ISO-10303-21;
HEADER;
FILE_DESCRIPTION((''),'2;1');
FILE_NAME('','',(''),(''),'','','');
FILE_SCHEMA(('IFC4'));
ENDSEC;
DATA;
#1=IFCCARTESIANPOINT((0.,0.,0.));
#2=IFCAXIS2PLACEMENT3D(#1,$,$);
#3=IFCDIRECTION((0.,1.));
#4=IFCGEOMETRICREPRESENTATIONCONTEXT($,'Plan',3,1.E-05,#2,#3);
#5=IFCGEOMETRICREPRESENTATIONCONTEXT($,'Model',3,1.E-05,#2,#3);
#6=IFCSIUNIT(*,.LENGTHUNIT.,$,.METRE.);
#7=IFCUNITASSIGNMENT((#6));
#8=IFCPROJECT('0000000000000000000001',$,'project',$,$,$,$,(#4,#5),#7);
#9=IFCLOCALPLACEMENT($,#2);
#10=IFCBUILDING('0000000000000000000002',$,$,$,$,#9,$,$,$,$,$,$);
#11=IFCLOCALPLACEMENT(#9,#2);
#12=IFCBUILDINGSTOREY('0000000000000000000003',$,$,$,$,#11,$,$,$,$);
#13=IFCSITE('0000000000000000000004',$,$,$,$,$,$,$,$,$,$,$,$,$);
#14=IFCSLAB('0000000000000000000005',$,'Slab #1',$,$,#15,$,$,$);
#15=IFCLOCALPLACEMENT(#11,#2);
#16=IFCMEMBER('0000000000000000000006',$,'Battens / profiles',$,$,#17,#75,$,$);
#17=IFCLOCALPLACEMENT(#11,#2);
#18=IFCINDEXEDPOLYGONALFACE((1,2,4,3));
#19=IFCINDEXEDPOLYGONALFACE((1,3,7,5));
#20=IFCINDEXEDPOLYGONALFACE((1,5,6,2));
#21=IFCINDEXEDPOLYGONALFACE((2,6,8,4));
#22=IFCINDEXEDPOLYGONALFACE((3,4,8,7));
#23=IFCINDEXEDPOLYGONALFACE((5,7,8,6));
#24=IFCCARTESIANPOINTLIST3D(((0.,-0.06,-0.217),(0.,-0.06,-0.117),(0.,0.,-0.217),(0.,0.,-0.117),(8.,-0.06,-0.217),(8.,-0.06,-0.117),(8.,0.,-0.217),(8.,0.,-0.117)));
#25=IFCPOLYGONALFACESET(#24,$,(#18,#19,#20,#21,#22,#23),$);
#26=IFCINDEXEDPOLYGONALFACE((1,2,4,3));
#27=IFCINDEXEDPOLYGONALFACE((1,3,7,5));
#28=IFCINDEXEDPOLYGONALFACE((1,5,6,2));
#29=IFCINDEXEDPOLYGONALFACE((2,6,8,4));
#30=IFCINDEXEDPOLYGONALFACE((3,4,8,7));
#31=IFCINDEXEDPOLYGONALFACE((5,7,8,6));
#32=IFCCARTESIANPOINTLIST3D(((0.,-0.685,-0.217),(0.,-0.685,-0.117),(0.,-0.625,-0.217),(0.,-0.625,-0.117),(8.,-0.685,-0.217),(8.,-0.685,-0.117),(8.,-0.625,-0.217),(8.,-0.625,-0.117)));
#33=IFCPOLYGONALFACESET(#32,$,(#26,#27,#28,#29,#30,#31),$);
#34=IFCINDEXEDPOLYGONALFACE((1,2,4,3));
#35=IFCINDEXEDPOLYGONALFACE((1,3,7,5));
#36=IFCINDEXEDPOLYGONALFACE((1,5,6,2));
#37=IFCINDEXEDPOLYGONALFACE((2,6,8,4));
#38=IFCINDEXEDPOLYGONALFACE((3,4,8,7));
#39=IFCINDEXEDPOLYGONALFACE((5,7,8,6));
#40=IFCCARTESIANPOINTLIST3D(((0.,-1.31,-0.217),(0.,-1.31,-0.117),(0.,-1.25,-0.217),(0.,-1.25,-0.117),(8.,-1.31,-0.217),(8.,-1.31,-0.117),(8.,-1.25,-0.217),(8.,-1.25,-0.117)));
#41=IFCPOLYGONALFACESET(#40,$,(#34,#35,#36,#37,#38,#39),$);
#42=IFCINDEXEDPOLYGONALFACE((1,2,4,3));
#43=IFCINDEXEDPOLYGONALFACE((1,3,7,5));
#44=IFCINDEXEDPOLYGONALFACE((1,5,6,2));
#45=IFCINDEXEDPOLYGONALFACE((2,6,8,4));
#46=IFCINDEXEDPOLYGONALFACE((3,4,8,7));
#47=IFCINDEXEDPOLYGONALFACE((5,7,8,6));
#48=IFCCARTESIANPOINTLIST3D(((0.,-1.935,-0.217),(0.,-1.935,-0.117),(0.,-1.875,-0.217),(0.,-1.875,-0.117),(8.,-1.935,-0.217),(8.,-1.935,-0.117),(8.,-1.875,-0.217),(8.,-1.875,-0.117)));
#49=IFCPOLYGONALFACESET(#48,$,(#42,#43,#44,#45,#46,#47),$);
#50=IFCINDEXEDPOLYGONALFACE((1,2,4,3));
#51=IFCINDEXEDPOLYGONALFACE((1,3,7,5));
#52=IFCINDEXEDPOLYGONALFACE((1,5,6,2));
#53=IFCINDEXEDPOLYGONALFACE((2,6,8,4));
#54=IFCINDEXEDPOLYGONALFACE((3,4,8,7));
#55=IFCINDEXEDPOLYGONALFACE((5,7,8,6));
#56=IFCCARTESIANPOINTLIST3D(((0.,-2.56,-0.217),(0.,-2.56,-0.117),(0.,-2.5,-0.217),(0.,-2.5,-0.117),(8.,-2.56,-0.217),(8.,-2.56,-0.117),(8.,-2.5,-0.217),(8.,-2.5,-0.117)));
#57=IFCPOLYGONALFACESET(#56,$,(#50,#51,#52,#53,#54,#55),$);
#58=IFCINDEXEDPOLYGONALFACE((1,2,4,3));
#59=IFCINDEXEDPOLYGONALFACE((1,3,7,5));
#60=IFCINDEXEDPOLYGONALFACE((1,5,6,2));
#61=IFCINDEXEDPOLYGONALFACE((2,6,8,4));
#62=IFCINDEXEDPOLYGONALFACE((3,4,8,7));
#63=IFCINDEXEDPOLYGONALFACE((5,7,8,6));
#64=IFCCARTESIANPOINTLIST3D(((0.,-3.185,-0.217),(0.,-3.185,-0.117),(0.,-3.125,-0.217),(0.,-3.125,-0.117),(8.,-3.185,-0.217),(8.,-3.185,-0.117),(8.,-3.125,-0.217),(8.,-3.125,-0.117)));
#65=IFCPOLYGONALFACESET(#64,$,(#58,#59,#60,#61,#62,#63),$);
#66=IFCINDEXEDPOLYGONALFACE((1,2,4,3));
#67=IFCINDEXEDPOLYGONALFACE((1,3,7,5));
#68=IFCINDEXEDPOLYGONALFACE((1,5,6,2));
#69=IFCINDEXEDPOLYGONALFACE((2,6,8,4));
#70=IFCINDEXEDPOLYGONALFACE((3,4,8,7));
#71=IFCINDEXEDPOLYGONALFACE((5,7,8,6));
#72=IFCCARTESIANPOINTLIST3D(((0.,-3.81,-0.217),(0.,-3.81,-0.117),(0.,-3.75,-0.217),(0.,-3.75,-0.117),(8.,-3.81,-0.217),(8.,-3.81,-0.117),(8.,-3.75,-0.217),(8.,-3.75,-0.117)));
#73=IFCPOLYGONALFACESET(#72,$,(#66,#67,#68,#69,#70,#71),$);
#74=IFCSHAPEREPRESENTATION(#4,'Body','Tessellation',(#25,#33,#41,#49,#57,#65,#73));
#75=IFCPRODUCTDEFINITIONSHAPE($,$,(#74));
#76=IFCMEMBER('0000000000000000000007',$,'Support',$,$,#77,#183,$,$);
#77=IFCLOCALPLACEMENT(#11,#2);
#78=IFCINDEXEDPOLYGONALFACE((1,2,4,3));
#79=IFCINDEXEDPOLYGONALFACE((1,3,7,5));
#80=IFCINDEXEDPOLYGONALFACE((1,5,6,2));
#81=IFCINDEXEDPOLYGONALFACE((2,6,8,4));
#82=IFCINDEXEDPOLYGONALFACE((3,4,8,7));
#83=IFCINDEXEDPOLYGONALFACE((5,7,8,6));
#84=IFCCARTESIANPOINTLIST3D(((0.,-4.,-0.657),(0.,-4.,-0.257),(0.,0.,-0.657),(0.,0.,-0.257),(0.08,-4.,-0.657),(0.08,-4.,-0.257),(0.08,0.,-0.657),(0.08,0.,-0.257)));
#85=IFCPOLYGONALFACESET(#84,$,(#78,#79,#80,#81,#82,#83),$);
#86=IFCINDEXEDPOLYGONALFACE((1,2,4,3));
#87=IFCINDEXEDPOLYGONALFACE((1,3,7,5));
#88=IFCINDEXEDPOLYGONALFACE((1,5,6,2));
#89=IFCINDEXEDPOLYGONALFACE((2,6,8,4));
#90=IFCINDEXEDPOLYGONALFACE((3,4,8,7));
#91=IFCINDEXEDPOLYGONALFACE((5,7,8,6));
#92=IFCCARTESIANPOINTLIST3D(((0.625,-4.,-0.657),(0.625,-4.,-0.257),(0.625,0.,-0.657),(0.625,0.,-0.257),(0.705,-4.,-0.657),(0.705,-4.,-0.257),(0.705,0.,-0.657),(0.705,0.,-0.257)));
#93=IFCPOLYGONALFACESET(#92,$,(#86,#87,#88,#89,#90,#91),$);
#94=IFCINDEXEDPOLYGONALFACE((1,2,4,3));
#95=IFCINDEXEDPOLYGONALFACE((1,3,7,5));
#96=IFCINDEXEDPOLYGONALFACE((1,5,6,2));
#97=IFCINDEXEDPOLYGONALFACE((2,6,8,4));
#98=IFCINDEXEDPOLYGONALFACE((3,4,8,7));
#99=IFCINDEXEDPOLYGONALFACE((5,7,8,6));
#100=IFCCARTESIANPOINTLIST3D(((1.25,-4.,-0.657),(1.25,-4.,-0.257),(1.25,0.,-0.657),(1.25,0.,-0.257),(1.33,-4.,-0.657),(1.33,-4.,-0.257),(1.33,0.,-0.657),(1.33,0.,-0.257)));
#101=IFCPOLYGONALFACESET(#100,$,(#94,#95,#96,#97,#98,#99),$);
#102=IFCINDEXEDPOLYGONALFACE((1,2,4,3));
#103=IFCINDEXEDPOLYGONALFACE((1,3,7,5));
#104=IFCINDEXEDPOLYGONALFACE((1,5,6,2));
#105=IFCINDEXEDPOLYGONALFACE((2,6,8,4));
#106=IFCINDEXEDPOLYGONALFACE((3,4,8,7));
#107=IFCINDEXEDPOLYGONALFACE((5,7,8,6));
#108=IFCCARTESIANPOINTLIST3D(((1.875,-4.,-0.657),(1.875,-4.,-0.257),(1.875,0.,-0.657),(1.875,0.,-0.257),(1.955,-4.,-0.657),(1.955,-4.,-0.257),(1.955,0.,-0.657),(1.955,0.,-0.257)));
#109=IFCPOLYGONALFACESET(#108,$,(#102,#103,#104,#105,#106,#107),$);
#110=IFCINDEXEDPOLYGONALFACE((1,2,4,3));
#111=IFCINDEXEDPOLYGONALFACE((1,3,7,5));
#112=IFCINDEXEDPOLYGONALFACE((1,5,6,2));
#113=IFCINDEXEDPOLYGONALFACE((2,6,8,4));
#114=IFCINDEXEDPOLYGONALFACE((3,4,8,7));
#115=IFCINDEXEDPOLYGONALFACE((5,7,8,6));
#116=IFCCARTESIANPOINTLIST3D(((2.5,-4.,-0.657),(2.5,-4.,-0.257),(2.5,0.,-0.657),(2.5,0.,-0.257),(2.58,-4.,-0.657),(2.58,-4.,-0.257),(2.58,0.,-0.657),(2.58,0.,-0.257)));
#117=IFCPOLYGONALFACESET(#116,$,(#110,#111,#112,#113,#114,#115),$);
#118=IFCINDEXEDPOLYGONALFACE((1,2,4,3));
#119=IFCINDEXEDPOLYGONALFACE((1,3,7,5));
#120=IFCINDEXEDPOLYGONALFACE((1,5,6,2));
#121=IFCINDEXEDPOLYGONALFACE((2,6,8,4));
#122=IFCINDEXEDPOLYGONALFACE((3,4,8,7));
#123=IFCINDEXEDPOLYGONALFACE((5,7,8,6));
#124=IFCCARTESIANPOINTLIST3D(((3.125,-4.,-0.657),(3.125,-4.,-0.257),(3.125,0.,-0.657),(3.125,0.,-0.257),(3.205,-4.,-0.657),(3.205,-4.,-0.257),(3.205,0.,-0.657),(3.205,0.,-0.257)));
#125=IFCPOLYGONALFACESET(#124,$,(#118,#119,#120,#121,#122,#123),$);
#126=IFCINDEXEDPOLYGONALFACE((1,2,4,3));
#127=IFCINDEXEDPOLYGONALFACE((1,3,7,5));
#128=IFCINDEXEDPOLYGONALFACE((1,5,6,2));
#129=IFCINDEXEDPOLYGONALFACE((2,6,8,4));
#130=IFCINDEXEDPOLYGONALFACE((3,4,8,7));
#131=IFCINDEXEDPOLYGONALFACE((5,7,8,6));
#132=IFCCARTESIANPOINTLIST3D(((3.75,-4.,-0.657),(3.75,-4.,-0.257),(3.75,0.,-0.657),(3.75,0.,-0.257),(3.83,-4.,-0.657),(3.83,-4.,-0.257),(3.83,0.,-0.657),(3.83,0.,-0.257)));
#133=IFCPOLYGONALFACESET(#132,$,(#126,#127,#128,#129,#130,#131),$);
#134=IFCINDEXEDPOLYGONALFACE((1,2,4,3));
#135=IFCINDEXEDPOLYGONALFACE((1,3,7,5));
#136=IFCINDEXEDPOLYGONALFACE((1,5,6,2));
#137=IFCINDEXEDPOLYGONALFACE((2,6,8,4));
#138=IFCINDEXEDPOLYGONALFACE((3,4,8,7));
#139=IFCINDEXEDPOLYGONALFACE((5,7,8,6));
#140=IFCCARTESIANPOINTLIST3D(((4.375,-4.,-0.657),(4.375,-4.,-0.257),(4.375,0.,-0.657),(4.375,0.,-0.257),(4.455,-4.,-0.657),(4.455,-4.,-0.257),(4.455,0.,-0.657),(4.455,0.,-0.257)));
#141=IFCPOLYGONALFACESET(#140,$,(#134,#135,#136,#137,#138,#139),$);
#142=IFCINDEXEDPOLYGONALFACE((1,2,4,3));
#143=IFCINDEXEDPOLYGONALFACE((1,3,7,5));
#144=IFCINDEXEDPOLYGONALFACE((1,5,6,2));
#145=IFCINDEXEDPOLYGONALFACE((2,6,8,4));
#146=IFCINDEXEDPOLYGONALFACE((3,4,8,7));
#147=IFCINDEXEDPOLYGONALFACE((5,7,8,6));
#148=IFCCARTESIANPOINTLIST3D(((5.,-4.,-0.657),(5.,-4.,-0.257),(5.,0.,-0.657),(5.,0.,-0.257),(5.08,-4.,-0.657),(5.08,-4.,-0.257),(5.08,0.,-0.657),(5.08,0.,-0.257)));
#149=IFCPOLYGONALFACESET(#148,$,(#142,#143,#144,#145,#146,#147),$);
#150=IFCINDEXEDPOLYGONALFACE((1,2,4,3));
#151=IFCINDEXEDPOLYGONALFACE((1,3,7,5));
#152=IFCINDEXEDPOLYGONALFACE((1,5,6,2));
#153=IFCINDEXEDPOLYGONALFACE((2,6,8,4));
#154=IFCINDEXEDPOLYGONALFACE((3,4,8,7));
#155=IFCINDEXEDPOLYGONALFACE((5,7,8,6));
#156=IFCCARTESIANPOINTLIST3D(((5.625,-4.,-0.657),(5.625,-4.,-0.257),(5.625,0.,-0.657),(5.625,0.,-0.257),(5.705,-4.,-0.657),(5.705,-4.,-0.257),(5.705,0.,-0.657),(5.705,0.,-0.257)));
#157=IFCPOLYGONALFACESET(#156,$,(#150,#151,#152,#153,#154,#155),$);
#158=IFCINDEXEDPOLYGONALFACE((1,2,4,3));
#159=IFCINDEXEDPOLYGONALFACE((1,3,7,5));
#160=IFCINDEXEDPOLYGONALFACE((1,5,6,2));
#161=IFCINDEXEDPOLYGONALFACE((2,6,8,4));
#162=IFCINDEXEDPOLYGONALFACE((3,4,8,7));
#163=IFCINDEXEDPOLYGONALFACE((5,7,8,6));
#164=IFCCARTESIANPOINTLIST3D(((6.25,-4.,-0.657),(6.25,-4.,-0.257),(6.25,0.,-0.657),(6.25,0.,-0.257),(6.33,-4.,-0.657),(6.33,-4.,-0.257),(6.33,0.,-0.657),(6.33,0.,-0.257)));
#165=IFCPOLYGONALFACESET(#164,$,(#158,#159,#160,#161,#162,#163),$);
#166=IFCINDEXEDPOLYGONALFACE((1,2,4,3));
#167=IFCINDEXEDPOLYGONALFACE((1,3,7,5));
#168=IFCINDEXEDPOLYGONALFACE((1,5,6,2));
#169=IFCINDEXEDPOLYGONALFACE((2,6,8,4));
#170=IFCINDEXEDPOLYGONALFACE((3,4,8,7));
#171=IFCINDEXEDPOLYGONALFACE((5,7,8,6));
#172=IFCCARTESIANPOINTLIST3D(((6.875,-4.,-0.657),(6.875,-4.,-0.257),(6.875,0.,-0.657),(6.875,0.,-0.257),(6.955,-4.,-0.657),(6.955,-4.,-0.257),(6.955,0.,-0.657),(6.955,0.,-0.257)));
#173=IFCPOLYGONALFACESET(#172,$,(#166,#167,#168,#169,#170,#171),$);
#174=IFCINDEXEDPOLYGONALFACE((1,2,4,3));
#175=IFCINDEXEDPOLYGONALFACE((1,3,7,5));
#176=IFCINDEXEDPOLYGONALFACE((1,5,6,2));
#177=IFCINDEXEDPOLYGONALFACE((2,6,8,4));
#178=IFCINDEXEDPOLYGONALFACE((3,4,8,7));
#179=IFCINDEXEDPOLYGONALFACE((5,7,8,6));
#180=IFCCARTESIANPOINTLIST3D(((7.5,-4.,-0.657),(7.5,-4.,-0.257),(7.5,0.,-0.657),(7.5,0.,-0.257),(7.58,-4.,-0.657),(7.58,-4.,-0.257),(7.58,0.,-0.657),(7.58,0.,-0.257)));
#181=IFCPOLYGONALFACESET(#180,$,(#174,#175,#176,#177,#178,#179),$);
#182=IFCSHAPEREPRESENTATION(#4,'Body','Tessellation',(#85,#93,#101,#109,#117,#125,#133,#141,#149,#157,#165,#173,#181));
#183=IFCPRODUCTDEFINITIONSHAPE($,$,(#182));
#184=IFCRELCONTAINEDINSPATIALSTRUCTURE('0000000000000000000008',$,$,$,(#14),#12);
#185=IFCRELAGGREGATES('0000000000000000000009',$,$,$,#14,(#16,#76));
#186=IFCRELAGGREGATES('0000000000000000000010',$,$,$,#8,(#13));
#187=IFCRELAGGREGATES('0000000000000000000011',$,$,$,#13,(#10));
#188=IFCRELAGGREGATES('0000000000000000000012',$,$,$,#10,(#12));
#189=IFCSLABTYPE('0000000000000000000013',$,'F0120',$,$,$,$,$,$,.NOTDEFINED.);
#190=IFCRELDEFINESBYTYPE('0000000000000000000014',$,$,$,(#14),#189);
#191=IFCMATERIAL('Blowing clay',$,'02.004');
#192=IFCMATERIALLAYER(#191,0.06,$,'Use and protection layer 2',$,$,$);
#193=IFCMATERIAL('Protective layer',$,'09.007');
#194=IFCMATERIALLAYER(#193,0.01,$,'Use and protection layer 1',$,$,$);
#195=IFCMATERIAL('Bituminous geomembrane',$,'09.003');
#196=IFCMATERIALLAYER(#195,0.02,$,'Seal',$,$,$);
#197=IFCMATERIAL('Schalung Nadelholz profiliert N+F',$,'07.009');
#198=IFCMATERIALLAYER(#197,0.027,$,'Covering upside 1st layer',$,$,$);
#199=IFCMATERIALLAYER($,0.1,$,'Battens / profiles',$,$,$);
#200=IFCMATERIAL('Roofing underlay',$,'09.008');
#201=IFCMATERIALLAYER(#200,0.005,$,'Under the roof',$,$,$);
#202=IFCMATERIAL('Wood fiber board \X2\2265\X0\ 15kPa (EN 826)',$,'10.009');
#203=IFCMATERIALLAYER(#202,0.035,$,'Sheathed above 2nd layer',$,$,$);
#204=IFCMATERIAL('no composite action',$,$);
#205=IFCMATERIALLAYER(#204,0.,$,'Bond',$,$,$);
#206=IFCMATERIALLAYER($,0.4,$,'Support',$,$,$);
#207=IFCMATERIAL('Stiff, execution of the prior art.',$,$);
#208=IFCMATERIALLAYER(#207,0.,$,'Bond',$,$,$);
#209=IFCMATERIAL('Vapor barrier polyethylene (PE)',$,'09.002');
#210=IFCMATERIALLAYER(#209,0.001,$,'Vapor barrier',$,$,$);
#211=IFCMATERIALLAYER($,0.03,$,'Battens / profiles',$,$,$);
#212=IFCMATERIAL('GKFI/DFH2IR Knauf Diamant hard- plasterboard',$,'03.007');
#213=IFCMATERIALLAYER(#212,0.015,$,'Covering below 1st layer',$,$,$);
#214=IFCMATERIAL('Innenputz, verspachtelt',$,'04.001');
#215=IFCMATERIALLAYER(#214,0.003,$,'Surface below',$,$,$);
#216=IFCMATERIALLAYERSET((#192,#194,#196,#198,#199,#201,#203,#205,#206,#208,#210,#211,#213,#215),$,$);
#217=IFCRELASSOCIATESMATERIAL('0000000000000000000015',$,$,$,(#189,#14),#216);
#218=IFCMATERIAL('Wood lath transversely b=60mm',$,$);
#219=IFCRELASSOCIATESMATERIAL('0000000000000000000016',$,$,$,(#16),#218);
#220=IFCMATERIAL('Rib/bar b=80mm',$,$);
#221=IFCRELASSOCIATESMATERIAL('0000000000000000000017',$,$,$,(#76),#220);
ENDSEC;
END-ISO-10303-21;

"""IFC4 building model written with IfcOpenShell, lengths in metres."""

from ifc_helpers import new_model, si_unit, direction, frame, frame_2d, origin, place, context, project, spatial, rectangle, extrude, material, layer, layer_set, type_object, element, aggregate, save


model = new_model("IFC4")

# Units and contexts
plan_context = context("Plan", 3, precision=1e-05, world=origin(), true_north=direction((0.0, 1.0)))
model_context = context("Model", 3, precision=1e-05, world=origin(), true_north=direction((0.0, 1.0)))
ifc_project = project(units=[si_unit("LENGTHUNIT", "METRE")], contexts=[plan_context, model_context])

# Site, building, storey
site = spatial("IfcSite", under=ifc_project)
building_placement = place(None, origin())
building = spatial("IfcBuilding", under=site, at=building_placement)
storey_placement = place(building_placement, origin())
storey = spatial("IfcBuildingStorey", under=building, at=storey_placement)

# Slab, members
ifc_material_1 = material(Name="Blowing clay", Category="02.004")
ifc_layer_1 = layer(ifc_material_1, 0.06, Name="Use and protection layer 2")
ifc_material_2 = material(Name="Protective layer", Category="09.007")
ifc_layer_2 = layer(ifc_material_2, 0.01, Name="Use and protection layer 1")
ifc_material_3 = material(Name="Bituminous geomembrane", Category="09.003")
ifc_layer_3 = layer(ifc_material_3, 0.02, Name="Seal")
ifc_material_4 = material(Name="Schalung Nadelholz profiliert N+F", Category="07.009")
ifc_layer_4 = layer(ifc_material_4, 0.027, Name="Covering upside 1st layer")
ifc_layer_5 = layer(None, 0.1, Name="Battens / profiles")
ifc_material_5 = material(Name="Roofing underlay", Category="09.008")
ifc_layer_6 = layer(ifc_material_5, 0.005, Name="Under the roof")
ifc_material_6 = material(Name="Wood fiber board ≥ 15kPa (EN 826)", Category="10.009")
ifc_layer_7 = layer(ifc_material_6, 0.035, Name="Sheathed above 2nd layer")
ifc_material_7 = material(Name="no composite action")
ifc_layer_8 = layer(ifc_material_7, 0.0, Name="Bond")
ifc_layer_9 = layer(None, 0.4, Name="Support")
ifc_material_8 = material(Name="Stiff, execution of the prior art.")
ifc_layer_10 = layer(ifc_material_8, 0.0, Name="Bond")
ifc_material_9 = material(Name="Vapor barrier polyethylene (PE)", Category="09.002")
ifc_layer_11 = layer(ifc_material_9, 0.001, Name="Vapor barrier")
ifc_layer_12 = layer(None, 0.03, Name="Battens / profiles")
ifc_material_10 = material(Name="GKFI/DFH2IR Knauf Diamant hard- plasterboard", Category="03.007")
ifc_layer_13 = layer(ifc_material_10, 0.015, Name="Covering below 1st layer")
ifc_material_11 = material(Name="Innenputz, verspachtelt", Category="04.001")
ifc_layer_14 = layer(ifc_material_11, 0.003, Name="Surface below")
ifc_layer_set = layer_set([ifc_layer_1, ifc_layer_2, ifc_layer_3, ifc_layer_4, ifc_layer_5, ifc_layer_6, ifc_layer_7, ifc_layer_8, ifc_layer_9, ifc_layer_10, ifc_layer_11, ifc_layer_12, ifc_layer_13, ifc_layer_14])
slab_type = type_object("IfcSlabType", Name="F0120", PredefinedType="NOTDEFINED", material=ifc_layer_set)
slab_placement = place(None, frame((0.0, 0.0, 0.0), z_axis=(0.0, 0.0, -1.0), x_axis=(1.0, 0.0, 0.0)))
slab = element("IfcSlab", 1, at=slab_placement, inside=storey, type_object=slab_type, material=ifc_layer_set, Name="Slab #1")
ifc_material_12 = material(Name="Wood lath transversely b=60mm")
member_1_placement = place(slab_placement, origin())
member_1 = element("IfcMember", 2, at=member_1_placement, material=ifc_material_12, Name="Battens / profiles", context=plan_context, shape_type="SweptSolid", body=[
    extrude(rectangle(XDim=0.06, YDim=0.1, at=frame_2d((0.03, 0.05), x_axis=(1.0, 0.0))), frame((0.0, 0.0, 0.117), z_axis=(1.0, 0.0, 0.0), x_axis=(0.0, 1.0, 0.0)), (0.0, 0.0, 1.0), 8.0),
    extrude(rectangle(XDim=0.06, YDim=0.1, at=frame_2d((0.03, 0.05), x_axis=(1.0, 0.0))), frame((0.0, 0.625, 0.117), z_axis=(1.0, 0.0, 0.0), x_axis=(0.0, 1.0, 0.0)), (0.0, 0.0, 1.0), 8.0),
    extrude(rectangle(XDim=0.06, YDim=0.1, at=frame_2d((0.03, 0.05), x_axis=(1.0, 0.0))), frame((0.0, 1.25, 0.117), z_axis=(1.0, 0.0, 0.0), x_axis=(0.0, 1.0, 0.0)), (0.0, 0.0, 1.0), 8.0),
    extrude(rectangle(XDim=0.06, YDim=0.1, at=frame_2d((0.03, 0.05), x_axis=(1.0, 0.0))), frame((0.0, 1.875, 0.117), z_axis=(1.0, 0.0, 0.0), x_axis=(0.0, 1.0, 0.0)), (0.0, 0.0, 1.0), 8.0),
    extrude(rectangle(XDim=0.06, YDim=0.1, at=frame_2d((0.03, 0.05), x_axis=(1.0, 0.0))), frame((0.0, 2.5, 0.117), z_axis=(1.0, 0.0, 0.0), x_axis=(0.0, 1.0, 0.0)), (0.0, 0.0, 1.0), 8.0),
    extrude(rectangle(XDim=0.06, YDim=0.1, at=frame_2d((0.03, 0.05), x_axis=(1.0, 0.0))), frame((0.0, 3.125, 0.117), z_axis=(1.0, 0.0, 0.0), x_axis=(0.0, 1.0, 0.0)), (0.0, 0.0, 1.0), 8.0),
    extrude(rectangle(XDim=0.06, YDim=0.1, at=frame_2d((0.03, 0.05), x_axis=(1.0, 0.0))), frame((0.0, 3.75, 0.117), z_axis=(1.0, 0.0, 0.0), x_axis=(0.0, 1.0, 0.0)), (0.0, 0.0, 1.0), 8.0),
])
ifc_material_13 = material(Name="Rib/bar b=80mm")
member_2_placement = place(slab_placement, origin())
member_2 = element("IfcMember", 3, at=member_2_placement, material=ifc_material_13, Name="Support", context=plan_context, shape_type="SweptSolid", body=[
    extrude(rectangle(XDim=0.08, YDim=0.4, at=frame_2d((0.04, 0.2), x_axis=(1.0, 0.0))), frame((0.0, 4.0, 0.257), z_axis=(0.0, -1.0, 0.0), x_axis=(1.0, 0.0, 0.0)), (0.0, 0.0, 1.0), 4.0),
    extrude(rectangle(XDim=0.08, YDim=0.4, at=frame_2d((0.04, 0.2), x_axis=(1.0, 0.0))), frame((0.625, 4.0, 0.257), z_axis=(0.0, -1.0, 0.0), x_axis=(1.0, 0.0, 0.0)), (0.0, 0.0, 1.0), 4.0),
    extrude(rectangle(XDim=0.08, YDim=0.4, at=frame_2d((0.04, 0.2), x_axis=(1.0, 0.0))), frame((1.25, 4.0, 0.257), z_axis=(0.0, -1.0, 0.0), x_axis=(1.0, 0.0, 0.0)), (0.0, 0.0, 1.0), 4.0),
    extrude(rectangle(XDim=0.08, YDim=0.4, at=frame_2d((0.04, 0.2), x_axis=(1.0, 0.0))), frame((1.875, 4.0, 0.257), z_axis=(0.0, -1.0, 0.0), x_axis=(1.0, 0.0, 0.0)), (0.0, 0.0, 1.0), 4.0),
    extrude(rectangle(XDim=0.08, YDim=0.4, at=frame_2d((0.04, 0.2), x_axis=(1.0, 0.0))), frame((2.5, 4.0, 0.257), z_axis=(0.0, -1.0, 0.0), x_axis=(1.0, 0.0, 0.0)), (0.0, 0.0, 1.0), 4.0),
    extrude(rectangle(XDim=0.08, YDim=0.4, at=frame_2d((0.04, 0.2), x_axis=(1.0, 0.0))), frame((3.125, 4.0, 0.257), z_axis=(0.0, -1.0, 0.0), x_axis=(1.0, 0.0, 0.0)), (0.0, 0.0, 1.0), 4.0),
    extrude(rectangle(XDim=0.08, YDim=0.4, at=frame_2d((0.04, 0.2), x_axis=(1.0, 0.0))), frame((3.75, 4.0, 0.257), z_axis=(0.0, -1.0, 0.0), x_axis=(1.0, 0.0, 0.0)), (0.0, 0.0, 1.0), 4.0),
    extrude(rectangle(XDim=0.08, YDim=0.4, at=frame_2d((0.04, 0.2), x_axis=(1.0, 0.0))), frame((4.375, 4.0, 0.257), z_axis=(0.0, -1.0, 0.0), x_axis=(1.0, 0.0, 0.0)), (0.0, 0.0, 1.0), 4.0),
    extrude(rectangle(XDim=0.08, YDim=0.4, at=frame_2d((0.04, 0.2), x_axis=(1.0, 0.0))), frame((5.0, 4.0, 0.257), z_axis=(0.0, -1.0, 0.0), x_axis=(1.0, 0.0, 0.0)), (0.0, 0.0, 1.0), 4.0),
    extrude(rectangle(XDim=0.08, YDim=0.4, at=frame_2d((0.04, 0.2), x_axis=(1.0, 0.0))), frame((5.625, 4.0, 0.257), z_axis=(0.0, -1.0, 0.0), x_axis=(1.0, 0.0, 0.0)), (0.0, 0.0, 1.0), 4.0),
    extrude(rectangle(XDim=0.08, YDim=0.4, at=frame_2d((0.04, 0.2), x_axis=(1.0, 0.0))), frame((6.25, 4.0, 0.257), z_axis=(0.0, -1.0, 0.0), x_axis=(1.0, 0.0, 0.0)), (0.0, 0.0, 1.0), 4.0),
    extrude(rectangle(XDim=0.08, YDim=0.4, at=frame_2d((0.04, 0.2), x_axis=(1.0, 0.0))), frame((6.875, 4.0, 0.257), z_axis=(0.0, -1.0, 0.0), x_axis=(1.0, 0.0, 0.0)), (0.0, 0.0, 1.0), 4.0),
    extrude(rectangle(XDim=0.08, YDim=0.4, at=frame_2d((0.04, 0.2), x_axis=(1.0, 0.0))), frame((7.5, 4.0, 0.257), z_axis=(0.0, -1.0, 0.0), x_axis=(1.0, 0.0, 0.0)), (0.0, 0.0, 1.0), 4.0),
])
aggregate(slab, [member_1, member_2])

save(model, "model.ifc")
